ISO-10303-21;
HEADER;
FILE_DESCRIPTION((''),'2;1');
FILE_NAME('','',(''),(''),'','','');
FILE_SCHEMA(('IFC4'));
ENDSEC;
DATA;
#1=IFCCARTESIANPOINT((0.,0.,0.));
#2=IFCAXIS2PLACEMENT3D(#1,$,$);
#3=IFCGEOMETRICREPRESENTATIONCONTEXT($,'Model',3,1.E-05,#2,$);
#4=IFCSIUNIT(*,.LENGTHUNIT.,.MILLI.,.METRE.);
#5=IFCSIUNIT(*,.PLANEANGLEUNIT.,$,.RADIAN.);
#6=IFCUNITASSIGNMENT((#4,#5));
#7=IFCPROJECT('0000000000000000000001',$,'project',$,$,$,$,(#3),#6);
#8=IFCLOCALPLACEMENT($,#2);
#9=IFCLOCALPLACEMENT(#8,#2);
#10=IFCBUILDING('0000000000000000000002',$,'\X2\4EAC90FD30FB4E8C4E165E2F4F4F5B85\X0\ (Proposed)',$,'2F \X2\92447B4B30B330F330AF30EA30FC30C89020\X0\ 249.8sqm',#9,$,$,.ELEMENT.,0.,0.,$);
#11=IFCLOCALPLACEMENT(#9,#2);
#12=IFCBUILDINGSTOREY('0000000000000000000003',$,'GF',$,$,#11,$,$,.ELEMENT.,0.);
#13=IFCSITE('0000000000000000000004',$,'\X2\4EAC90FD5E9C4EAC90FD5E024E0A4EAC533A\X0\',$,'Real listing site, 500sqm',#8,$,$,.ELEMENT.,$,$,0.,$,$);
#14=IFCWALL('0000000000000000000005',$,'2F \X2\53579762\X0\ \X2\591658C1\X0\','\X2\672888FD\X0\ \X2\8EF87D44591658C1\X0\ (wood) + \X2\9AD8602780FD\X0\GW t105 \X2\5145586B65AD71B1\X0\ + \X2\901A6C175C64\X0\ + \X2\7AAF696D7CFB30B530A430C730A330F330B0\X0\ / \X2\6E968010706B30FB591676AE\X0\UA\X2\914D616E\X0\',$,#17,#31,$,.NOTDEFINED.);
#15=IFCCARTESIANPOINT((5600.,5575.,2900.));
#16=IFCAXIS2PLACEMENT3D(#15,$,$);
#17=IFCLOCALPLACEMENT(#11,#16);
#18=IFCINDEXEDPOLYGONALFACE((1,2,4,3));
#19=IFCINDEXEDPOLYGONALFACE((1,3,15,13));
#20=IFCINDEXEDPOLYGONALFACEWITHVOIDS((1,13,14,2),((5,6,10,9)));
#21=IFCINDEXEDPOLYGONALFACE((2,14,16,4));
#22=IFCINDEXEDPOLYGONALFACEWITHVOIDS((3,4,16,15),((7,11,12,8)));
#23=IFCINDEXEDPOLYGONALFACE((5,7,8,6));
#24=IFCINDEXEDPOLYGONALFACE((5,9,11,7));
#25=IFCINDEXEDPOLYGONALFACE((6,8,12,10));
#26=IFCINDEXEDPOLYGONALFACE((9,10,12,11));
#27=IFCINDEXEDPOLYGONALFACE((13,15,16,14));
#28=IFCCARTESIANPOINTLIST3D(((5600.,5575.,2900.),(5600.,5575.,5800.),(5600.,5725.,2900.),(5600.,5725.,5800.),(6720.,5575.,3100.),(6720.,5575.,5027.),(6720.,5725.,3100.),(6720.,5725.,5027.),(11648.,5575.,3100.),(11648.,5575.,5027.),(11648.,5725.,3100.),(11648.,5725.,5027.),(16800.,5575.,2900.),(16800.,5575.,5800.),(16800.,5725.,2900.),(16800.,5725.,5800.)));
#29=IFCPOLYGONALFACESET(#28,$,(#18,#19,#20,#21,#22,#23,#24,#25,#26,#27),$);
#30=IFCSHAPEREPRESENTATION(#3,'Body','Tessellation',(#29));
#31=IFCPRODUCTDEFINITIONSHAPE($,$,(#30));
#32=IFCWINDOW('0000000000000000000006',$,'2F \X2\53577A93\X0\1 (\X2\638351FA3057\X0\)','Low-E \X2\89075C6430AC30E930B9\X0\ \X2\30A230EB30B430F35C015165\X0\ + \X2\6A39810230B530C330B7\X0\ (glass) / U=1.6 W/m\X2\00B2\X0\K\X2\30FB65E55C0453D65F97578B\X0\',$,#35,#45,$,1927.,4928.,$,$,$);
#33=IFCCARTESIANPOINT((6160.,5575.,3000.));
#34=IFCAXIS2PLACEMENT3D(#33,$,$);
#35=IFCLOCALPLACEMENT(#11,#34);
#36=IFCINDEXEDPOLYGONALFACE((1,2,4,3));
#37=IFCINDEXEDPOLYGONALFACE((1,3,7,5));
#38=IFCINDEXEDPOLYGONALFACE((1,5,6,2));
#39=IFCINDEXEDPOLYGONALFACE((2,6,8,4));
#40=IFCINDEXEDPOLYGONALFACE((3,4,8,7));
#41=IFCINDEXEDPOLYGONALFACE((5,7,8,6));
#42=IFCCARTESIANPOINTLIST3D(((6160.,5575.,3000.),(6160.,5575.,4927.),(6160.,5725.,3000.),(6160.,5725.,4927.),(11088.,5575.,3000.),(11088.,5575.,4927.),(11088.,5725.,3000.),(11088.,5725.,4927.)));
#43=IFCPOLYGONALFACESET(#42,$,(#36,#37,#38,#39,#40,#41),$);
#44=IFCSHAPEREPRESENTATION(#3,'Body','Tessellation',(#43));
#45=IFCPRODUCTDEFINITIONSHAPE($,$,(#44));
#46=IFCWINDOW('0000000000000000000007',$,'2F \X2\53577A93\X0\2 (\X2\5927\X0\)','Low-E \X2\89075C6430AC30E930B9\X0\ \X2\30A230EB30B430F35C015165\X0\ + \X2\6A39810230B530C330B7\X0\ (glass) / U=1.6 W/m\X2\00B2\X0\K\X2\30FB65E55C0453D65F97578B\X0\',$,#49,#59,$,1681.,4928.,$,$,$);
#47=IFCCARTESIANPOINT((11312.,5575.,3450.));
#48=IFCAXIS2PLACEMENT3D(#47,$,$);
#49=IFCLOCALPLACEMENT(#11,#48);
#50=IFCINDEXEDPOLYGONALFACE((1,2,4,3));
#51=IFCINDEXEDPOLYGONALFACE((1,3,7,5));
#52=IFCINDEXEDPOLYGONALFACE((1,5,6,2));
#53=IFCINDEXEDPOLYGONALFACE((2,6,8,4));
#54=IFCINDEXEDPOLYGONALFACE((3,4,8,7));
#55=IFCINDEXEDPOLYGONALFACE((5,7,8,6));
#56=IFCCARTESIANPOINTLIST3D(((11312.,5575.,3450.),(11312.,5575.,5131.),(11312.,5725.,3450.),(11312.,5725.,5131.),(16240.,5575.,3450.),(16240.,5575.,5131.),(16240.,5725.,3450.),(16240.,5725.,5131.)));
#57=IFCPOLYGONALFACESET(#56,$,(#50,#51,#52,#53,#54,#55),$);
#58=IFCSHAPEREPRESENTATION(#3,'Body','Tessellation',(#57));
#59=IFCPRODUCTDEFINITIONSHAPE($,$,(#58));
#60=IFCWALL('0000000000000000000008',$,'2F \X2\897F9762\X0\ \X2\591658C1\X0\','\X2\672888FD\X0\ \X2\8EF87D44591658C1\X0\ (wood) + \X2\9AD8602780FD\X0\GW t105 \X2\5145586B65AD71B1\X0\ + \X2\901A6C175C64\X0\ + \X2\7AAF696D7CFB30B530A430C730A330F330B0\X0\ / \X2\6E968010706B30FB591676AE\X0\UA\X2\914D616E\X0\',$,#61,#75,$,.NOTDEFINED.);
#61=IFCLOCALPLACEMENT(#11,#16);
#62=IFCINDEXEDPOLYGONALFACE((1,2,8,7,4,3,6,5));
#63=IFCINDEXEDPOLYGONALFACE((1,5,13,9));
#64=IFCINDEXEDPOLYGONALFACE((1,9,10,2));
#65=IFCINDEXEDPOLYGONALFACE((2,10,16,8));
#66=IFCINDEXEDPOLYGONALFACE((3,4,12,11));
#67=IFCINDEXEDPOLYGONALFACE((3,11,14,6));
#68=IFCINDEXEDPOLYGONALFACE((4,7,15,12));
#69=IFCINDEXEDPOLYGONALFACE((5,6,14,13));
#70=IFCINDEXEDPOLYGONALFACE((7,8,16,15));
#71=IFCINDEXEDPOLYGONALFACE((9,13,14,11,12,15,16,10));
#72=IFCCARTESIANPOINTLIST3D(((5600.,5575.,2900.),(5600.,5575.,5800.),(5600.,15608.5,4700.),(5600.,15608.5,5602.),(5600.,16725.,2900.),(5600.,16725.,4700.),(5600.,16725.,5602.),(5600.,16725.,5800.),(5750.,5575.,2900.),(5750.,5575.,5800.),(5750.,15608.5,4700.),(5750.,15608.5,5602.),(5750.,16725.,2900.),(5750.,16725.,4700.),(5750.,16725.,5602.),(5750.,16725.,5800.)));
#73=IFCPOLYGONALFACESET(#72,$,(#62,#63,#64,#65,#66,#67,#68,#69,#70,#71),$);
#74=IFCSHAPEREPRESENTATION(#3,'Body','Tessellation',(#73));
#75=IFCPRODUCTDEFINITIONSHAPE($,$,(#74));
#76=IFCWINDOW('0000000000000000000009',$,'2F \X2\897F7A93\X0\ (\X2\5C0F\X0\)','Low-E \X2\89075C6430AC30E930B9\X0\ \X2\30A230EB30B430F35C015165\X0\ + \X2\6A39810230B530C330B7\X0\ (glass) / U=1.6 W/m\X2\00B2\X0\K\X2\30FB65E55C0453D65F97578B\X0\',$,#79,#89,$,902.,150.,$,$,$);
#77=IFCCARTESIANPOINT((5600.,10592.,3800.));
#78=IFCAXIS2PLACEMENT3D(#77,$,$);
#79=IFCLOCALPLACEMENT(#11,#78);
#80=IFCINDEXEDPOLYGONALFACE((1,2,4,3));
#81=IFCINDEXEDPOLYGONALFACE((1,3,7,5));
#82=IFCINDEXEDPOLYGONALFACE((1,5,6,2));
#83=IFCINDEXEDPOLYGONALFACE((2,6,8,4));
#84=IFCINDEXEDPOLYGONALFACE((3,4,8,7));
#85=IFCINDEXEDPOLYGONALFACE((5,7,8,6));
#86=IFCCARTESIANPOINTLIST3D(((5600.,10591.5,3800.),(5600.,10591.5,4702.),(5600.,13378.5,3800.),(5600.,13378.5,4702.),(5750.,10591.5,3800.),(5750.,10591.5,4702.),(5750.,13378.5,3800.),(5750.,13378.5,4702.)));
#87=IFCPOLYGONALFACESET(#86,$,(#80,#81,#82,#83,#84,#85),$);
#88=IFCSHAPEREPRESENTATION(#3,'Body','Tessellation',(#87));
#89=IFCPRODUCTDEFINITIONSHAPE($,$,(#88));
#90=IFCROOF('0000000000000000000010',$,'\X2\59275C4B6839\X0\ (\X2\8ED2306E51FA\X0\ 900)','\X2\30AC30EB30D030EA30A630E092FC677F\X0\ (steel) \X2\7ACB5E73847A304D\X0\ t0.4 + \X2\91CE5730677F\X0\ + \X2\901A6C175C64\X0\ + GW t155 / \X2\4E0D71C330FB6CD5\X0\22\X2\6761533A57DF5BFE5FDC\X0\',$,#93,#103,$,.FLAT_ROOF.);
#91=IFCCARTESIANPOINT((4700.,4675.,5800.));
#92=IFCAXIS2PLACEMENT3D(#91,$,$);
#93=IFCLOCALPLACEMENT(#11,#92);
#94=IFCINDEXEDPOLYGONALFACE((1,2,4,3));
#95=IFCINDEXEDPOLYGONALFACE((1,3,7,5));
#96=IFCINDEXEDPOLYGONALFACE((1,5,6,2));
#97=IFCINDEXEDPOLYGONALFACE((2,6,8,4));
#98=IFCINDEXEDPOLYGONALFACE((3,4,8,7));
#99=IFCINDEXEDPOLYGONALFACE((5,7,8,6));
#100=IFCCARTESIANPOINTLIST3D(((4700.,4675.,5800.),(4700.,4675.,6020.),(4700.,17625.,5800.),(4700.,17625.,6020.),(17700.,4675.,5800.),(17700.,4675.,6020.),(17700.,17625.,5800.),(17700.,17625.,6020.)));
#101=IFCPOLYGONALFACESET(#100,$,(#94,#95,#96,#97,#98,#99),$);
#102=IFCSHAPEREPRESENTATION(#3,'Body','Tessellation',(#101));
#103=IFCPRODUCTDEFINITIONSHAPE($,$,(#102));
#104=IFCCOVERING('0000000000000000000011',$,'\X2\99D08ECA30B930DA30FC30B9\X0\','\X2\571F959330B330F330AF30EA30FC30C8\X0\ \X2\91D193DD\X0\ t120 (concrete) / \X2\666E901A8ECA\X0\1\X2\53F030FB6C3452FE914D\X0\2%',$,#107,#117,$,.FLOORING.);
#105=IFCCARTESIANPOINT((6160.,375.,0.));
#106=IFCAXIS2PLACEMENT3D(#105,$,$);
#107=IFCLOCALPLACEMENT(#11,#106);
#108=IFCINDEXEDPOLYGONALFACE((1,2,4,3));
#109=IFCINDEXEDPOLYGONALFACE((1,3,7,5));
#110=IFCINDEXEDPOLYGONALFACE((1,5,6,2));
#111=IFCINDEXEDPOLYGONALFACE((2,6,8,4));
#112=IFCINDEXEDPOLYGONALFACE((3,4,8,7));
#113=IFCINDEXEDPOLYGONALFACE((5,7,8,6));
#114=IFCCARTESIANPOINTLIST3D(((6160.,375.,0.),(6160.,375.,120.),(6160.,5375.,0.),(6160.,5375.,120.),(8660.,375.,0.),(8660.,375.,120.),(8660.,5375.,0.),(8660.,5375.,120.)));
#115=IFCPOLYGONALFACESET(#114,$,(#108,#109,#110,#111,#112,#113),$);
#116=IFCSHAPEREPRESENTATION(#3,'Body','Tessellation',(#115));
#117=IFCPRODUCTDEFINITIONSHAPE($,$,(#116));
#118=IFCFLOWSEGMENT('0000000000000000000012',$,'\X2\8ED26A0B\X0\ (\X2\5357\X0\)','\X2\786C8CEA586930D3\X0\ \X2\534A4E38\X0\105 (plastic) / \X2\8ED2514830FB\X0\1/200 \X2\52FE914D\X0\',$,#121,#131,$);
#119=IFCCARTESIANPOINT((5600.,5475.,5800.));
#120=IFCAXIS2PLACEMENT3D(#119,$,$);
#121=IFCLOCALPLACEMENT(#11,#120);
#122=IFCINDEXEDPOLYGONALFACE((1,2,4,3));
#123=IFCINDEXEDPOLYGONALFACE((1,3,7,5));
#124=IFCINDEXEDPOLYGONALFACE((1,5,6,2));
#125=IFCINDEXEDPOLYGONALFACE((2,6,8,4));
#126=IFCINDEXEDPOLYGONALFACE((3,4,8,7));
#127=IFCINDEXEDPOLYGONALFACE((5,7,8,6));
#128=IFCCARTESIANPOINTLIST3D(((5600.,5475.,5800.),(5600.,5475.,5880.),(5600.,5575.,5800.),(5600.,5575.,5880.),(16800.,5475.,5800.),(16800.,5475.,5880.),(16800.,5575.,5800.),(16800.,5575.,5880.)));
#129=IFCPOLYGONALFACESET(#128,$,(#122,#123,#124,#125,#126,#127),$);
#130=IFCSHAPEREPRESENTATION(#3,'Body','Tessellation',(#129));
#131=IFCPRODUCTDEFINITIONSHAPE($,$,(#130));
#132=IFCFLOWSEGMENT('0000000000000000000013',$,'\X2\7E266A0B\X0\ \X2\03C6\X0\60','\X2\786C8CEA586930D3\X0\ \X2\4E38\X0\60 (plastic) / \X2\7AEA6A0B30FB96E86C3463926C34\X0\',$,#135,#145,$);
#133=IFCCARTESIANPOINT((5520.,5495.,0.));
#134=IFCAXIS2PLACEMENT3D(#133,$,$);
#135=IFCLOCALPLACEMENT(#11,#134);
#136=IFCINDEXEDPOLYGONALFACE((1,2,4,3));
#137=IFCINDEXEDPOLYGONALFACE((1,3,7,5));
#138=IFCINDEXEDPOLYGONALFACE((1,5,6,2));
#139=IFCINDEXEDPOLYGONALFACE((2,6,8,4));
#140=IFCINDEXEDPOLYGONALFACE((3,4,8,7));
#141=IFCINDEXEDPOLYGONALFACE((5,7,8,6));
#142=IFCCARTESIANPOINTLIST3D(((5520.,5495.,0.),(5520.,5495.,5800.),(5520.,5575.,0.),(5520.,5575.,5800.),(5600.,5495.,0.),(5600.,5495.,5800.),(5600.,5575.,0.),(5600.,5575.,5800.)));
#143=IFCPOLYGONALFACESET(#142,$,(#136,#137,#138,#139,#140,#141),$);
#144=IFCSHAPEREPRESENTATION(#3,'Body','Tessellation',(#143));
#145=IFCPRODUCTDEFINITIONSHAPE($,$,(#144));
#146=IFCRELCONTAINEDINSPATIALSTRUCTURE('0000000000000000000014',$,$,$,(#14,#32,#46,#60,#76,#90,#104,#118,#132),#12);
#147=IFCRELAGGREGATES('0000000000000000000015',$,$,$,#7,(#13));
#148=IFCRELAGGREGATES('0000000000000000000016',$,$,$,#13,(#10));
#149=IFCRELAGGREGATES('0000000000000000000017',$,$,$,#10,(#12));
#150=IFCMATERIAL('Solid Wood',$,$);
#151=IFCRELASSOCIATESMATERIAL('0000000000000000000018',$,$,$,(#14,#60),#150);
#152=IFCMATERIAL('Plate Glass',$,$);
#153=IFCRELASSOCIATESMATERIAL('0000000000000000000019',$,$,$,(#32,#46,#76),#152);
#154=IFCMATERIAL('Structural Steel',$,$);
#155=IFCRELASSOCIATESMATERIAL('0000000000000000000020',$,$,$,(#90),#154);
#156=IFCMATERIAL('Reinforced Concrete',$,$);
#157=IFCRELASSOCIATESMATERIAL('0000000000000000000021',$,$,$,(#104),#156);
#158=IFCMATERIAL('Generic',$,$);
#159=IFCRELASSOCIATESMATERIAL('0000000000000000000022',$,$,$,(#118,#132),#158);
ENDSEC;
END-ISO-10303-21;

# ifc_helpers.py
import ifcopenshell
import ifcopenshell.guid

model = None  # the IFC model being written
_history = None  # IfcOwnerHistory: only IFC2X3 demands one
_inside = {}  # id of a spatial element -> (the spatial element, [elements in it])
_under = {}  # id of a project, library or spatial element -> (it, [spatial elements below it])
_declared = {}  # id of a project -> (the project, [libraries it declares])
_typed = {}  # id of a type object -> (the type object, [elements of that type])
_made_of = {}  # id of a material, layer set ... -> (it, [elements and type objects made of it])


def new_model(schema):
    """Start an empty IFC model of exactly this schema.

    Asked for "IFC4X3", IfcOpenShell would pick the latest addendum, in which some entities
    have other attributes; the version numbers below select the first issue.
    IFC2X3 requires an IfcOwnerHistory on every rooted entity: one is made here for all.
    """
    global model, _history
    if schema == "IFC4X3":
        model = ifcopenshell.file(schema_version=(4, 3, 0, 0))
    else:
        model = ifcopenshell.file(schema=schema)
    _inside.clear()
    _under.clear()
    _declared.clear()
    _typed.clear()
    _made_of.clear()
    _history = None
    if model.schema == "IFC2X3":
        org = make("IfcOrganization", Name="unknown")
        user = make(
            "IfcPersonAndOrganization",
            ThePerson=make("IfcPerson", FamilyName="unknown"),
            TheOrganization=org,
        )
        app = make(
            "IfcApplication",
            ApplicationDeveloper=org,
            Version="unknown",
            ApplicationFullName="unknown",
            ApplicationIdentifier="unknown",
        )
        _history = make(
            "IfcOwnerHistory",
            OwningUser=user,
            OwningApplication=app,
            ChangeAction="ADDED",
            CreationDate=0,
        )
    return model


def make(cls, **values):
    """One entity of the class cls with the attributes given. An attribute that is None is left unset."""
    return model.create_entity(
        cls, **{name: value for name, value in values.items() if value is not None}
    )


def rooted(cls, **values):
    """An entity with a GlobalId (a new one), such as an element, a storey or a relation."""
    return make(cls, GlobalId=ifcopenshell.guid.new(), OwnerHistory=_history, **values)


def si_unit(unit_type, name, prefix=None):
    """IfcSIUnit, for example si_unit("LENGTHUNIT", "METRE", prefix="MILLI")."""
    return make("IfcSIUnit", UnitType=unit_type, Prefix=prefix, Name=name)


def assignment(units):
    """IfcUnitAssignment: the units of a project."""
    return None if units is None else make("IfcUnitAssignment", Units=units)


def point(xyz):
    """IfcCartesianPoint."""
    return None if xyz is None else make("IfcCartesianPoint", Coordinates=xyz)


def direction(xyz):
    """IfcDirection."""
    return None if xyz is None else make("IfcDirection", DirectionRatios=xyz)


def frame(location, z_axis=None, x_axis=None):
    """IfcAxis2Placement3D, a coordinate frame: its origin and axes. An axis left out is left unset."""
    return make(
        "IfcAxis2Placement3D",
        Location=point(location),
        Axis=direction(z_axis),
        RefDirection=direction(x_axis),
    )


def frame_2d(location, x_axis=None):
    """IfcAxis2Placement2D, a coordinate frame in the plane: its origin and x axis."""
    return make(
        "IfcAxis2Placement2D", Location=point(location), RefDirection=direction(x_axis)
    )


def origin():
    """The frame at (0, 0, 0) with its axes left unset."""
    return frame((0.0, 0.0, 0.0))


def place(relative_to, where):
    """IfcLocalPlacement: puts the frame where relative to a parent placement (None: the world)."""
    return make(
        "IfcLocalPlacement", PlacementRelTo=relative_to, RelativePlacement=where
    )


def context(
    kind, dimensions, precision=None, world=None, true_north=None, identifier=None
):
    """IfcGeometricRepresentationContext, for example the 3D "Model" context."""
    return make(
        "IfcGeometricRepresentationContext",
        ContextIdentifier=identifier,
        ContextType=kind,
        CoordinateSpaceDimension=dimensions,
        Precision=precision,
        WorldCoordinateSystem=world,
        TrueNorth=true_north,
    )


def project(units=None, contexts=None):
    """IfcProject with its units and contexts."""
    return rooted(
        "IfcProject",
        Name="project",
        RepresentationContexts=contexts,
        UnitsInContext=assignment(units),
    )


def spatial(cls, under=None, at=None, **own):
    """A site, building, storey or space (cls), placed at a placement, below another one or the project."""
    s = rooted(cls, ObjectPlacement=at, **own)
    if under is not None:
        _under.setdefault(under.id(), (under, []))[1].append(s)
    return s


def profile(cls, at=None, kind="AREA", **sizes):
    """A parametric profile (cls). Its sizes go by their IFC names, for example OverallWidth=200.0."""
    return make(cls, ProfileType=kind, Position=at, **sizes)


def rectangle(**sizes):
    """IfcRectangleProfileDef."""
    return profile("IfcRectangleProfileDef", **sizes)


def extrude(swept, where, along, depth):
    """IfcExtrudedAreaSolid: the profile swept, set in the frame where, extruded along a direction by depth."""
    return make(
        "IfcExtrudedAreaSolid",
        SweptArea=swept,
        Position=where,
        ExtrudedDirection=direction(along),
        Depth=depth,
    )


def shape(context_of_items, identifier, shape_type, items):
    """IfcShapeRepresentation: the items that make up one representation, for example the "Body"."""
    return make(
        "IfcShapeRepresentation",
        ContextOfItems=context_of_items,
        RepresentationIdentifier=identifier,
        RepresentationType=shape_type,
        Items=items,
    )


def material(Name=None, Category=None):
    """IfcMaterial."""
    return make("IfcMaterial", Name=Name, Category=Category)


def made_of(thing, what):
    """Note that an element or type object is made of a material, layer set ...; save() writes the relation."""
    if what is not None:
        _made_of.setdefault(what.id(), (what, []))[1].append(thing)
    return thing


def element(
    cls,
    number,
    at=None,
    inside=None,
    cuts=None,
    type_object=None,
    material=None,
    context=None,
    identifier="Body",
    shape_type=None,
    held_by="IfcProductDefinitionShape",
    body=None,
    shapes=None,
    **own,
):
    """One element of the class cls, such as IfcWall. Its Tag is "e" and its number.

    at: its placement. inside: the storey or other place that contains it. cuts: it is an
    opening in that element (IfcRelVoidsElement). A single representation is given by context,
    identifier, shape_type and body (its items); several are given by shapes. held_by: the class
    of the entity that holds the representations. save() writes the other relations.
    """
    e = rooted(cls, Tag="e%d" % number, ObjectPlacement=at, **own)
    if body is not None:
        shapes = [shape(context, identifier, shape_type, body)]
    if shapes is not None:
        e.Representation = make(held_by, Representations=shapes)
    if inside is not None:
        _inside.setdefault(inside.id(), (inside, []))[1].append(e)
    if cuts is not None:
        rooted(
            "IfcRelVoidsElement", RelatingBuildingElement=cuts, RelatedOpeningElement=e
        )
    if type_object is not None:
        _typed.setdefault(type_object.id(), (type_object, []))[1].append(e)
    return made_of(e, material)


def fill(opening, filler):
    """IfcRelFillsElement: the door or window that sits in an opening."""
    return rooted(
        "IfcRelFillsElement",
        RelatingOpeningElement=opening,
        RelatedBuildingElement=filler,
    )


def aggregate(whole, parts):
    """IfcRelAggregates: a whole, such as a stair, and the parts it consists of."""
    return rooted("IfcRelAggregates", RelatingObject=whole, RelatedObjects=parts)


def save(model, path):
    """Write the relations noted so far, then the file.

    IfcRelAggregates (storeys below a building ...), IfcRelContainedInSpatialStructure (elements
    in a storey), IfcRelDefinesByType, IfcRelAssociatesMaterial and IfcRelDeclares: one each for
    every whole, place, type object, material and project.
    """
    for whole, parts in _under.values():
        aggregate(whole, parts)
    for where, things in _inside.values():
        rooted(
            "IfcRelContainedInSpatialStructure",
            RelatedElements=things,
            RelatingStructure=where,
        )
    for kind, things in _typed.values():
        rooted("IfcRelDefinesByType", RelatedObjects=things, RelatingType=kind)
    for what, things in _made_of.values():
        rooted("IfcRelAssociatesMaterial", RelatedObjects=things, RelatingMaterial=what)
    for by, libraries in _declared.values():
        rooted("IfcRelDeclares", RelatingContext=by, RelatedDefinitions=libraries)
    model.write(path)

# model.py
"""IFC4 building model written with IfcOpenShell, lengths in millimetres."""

from ifc_helpers import new_model, si_unit, frame, frame_2d, origin, place, context, project, spatial, rectangle, extrude, material, element, fill, save


model = new_model("IFC4")

# Units and contexts
model_context = context("Model", 3, precision=1e-05, world=origin())
ifc_project = project(units=[si_unit("LENGTHUNIT", "METRE", prefix="MILLI"), si_unit("PLANEANGLEUNIT", "RADIAN")], contexts=[model_context])

# Site, building, storey
site_placement = place(None, origin())
site = spatial("IfcSite", under=ifc_project, at=site_placement, Name="京都府京都市上京区", ObjectType="Real listing site, 500sqm", CompositionType="ELEMENT", RefElevation=0.0)
building_placement = place(site_placement, origin())
building = spatial("IfcBuilding", under=site, at=building_placement, Name="京都・二世帯住宅 (Proposed)", ObjectType="2F 鉄筋コンクリート造 249.8sqm", CompositionType="ELEMENT", ElevationOfRefHeight=0.0, ElevationOfTerrain=0.0)
storey_placement = place(building_placement, origin())
storey = spatial("IfcBuildingStorey", under=building, at=storey_placement, Name="GF", CompositionType="ELEMENT", Elevation=0.0)

# Shared definitions
ifc_material_1 = material(Name="Solid Wood")

# Shared definitions
ifc_material_2 = material(Name="Reinforced Concrete")

# Shared definitions
ifc_material_3 = material(Name="Plate Glass")

# Wall, openings, windows
wall_1_placement = place(storey_placement, frame((5600.0, 5575.0, 2900.0)))
wall_1 = element("IfcWall", 1, at=wall_1_placement, inside=storey, material=ifc_material_1, Name="2F 南面 外壁", Description="木製 軸組外壁 (wood) + 高性能GW t105 充填断熱 + 通気層 + 窯業系サイディング / 準耐火・外皮UA配慮", PredefinedType="NOTDEFINED", context=model_context, shape_type="SweptSolid", body=[
    extrude(rectangle(XDim=11200.0, YDim=150.0, at=frame_2d((5600.0, 75.0))), frame((5600.0, 5575.0, 2900.0)), (0.0, 0.0, 1.0), 2900.0),
])
opening_1_placement = place(storey_placement, frame((6160.0, 5575.0, 3000.0)))
opening_1 = element("IfcOpeningElement", 2, at=opening_1_placement, cuts=wall_1, PredefinedType="NOTDEFINED", context=model_context, shape_type="SweptSolid", body=[
    extrude(rectangle(XDim=4928.0, YDim=150.0, at=frame_2d((2464.0, 75.0))), frame((6160.0, 5575.0, 3000.0)), (0.0, 0.0, 1.0), 1927.0),
])
opening_2_placement = place(storey_placement, frame((11312.0, 5575.0, 3450.0)))
opening_2 = element("IfcOpeningElement", 3, at=opening_2_placement, cuts=wall_1, PredefinedType="NOTDEFINED", context=model_context, shape_type="SweptSolid", body=[
    extrude(rectangle(XDim=4928.0, YDim=150.0, at=frame_2d((2464.0, 75.0))), frame((11312.0, 5575.0, 3450.0)), (0.0, 0.0, 1.0), 1681.0),
])
window_1_placement = place(storey_placement, frame((6160.0, 5575.0, 3000.0)))
window_1 = element("IfcWindow", 4, at=window_1_placement, inside=storey, material=ifc_material_3, Name="2F 南窓1 (掃出し)", Description="Low-E 複層ガラス アルゴン封入 + 樹脂サッシ (glass) / U=1.6 W/m²K・日射取得型", OverallHeight=1927.0, OverallWidth=4928.0, context=model_context, shape_type="SweptSolid", body=[
    extrude(rectangle(XDim=4928.0, YDim=150.0, at=frame_2d((2464.0, 75.0))), frame((6160.0, 5575.0, 3000.0)), (0.0, 0.0, 1.0), 1927.0),
])
fill(opening_1, window_1)
window_2_placement = place(storey_placement, frame((11312.0, 5575.0, 3450.0)))
window_2 = element("IfcWindow", 5, at=window_2_placement, inside=storey, material=ifc_material_3, Name="2F 南窓2 (大)", Description="Low-E 複層ガラス アルゴン封入 + 樹脂サッシ (glass) / U=1.6 W/m²K・日射取得型", OverallHeight=1681.0, OverallWidth=4928.0, context=model_context, shape_type="SweptSolid", body=[
    extrude(rectangle(XDim=4928.0, YDim=150.0, at=frame_2d((2464.0, 75.0))), frame((11312.0, 5575.0, 3450.0)), (0.0, 0.0, 1.0), 1681.0),
])
fill(opening_2, window_2)

# Wall, opening, window
wall_2_placement = place(storey_placement, frame((5600.0, 5575.0, 2900.0)))
wall_2 = element("IfcWall", 6, at=wall_2_placement, inside=storey, material=ifc_material_1, Name="2F 西面 外壁", Description="木製 軸組外壁 (wood) + 高性能GW t105 充填断熱 + 通気層 + 窯業系サイディング / 準耐火・外皮UA配慮", PredefinedType="NOTDEFINED", context=model_context, shape_type="SweptSolid", body=[
    extrude(rectangle(XDim=150.0, YDim=11150.0, at=frame_2d((75.0, 5575.0))), frame((5600.0, 5575.0, 2900.0)), (0.0, 0.0, 1.0), 2900.0),
])
opening_3_placement = place(storey_placement, frame((5600.0, 10592.0, 3800.0)))
opening_3 = element("IfcOpeningElement", 7, at=opening_3_placement, cuts=wall_2, PredefinedType="NOTDEFINED", context=model_context, shape_type="SweptSolid", body=[
    extrude(rectangle(XDim=150.0, YDim=2787.0, at=frame_2d((75.0, 1393.0))), frame((5600.0, 10592.0, 3800.0)), (0.0, 0.0, 1.0), 902.0),
])
window_3_placement = place(storey_placement, frame((5600.0, 10592.0, 3800.0)))
window_3 = element("IfcWindow", 8, at=window_3_placement, inside=storey, material=ifc_material_3, Name="2F 西窓 (小)", Description="Low-E 複層ガラス アルゴン封入 + 樹脂サッシ (glass) / U=1.6 W/m²K・日射取得型", OverallHeight=902.0, OverallWidth=150.0, context=model_context, shape_type="SweptSolid", body=[
    extrude(rectangle(XDim=150.0, YDim=2787.0, at=frame_2d((75.0, 1393.0))), frame((5600.0, 10592.0, 3800.0)), (0.0, 0.0, 1.0), 902.0),
])
fill(opening_3, window_3)

# Roof
ifc_material_4 = material(Name="Structural Steel")
roof_placement = place(storey_placement, frame((4700.0, 4675.0, 5800.0)))
element("IfcRoof", 9, at=roof_placement, inside=storey, material=ifc_material_4, Name="大屋根 (軒の出 900)", Description="ガルバリウム鋼板 (steel) 立平葺き t0.4 + 野地板 + 通気層 + GW t155 / 不燃・法22条区域対応", PredefinedType="FLAT_ROOF", context=model_context, shape_type="SweptSolid", body=[
    extrude(rectangle(XDim=13000.0, YDim=12950.0, at=frame_2d((6500.0, 6475.0))), frame((4700.0, 4675.0, 5800.0)), (0.0, 0.0, 1.0), 220.0),
])

# Covering
covering_placement = place(storey_placement, frame((6160.0, 375.0, 0.0)))
element("IfcCovering", 10, at=covering_placement, inside=storey, material=ifc_material_2, Name="駐車スペース", Description="土間コンクリート 金鏝 t120 (concrete) / 普通車1台・水勾配2%", PredefinedType="FLOORING", context=model_context, shape_type="SweptSolid", body=[
    extrude(rectangle(XDim=2500.0, YDim=5000.0, at=frame_2d((1250.0, 2500.0))), frame((6160.0, 375.0, 0.0)), (0.0, 0.0, 1.0), 120.0),
])

# Flow segments
ifc_material_5 = material(Name="Generic")
flow_segment_1_placement = place(storey_placement, frame((5600.0, 5475.0, 5800.0)))
element("IfcFlowSegment", 11, at=flow_segment_1_placement, inside=storey, material=ifc_material_5, Name="軒樋 (南)", Description="硬質塩ビ 半丸105 (plastic) / 軒先・1/200 勾配", context=model_context, shape_type="SweptSolid", body=[
    extrude(rectangle(XDim=11200.0, YDim=100.0, at=frame_2d((5600.0, 50.0))), frame((5600.0, 5475.0, 5800.0)), (0.0, 0.0, 1.0), 80.0),
])
flow_segment_2_placement = place(storey_placement, frame((5520.0, 5495.0, 0.0)))
element("IfcFlowSegment", 12, at=flow_segment_2_placement, inside=storey, material=ifc_material_5, Name="縦樋 φ60", Description="硬質塩ビ 丸60 (plastic) / 竪樋・雨水排水", context=model_context, shape_type="SweptSolid", body=[
    extrude(rectangle(XDim=80.0, YDim=80.0, at=frame_2d((40.0, 40.0))), frame((5520.0, 5495.0, 0.0)), (0.0, 0.0, 1.0), 5800.0),
])

save(model, "model.ifc")
